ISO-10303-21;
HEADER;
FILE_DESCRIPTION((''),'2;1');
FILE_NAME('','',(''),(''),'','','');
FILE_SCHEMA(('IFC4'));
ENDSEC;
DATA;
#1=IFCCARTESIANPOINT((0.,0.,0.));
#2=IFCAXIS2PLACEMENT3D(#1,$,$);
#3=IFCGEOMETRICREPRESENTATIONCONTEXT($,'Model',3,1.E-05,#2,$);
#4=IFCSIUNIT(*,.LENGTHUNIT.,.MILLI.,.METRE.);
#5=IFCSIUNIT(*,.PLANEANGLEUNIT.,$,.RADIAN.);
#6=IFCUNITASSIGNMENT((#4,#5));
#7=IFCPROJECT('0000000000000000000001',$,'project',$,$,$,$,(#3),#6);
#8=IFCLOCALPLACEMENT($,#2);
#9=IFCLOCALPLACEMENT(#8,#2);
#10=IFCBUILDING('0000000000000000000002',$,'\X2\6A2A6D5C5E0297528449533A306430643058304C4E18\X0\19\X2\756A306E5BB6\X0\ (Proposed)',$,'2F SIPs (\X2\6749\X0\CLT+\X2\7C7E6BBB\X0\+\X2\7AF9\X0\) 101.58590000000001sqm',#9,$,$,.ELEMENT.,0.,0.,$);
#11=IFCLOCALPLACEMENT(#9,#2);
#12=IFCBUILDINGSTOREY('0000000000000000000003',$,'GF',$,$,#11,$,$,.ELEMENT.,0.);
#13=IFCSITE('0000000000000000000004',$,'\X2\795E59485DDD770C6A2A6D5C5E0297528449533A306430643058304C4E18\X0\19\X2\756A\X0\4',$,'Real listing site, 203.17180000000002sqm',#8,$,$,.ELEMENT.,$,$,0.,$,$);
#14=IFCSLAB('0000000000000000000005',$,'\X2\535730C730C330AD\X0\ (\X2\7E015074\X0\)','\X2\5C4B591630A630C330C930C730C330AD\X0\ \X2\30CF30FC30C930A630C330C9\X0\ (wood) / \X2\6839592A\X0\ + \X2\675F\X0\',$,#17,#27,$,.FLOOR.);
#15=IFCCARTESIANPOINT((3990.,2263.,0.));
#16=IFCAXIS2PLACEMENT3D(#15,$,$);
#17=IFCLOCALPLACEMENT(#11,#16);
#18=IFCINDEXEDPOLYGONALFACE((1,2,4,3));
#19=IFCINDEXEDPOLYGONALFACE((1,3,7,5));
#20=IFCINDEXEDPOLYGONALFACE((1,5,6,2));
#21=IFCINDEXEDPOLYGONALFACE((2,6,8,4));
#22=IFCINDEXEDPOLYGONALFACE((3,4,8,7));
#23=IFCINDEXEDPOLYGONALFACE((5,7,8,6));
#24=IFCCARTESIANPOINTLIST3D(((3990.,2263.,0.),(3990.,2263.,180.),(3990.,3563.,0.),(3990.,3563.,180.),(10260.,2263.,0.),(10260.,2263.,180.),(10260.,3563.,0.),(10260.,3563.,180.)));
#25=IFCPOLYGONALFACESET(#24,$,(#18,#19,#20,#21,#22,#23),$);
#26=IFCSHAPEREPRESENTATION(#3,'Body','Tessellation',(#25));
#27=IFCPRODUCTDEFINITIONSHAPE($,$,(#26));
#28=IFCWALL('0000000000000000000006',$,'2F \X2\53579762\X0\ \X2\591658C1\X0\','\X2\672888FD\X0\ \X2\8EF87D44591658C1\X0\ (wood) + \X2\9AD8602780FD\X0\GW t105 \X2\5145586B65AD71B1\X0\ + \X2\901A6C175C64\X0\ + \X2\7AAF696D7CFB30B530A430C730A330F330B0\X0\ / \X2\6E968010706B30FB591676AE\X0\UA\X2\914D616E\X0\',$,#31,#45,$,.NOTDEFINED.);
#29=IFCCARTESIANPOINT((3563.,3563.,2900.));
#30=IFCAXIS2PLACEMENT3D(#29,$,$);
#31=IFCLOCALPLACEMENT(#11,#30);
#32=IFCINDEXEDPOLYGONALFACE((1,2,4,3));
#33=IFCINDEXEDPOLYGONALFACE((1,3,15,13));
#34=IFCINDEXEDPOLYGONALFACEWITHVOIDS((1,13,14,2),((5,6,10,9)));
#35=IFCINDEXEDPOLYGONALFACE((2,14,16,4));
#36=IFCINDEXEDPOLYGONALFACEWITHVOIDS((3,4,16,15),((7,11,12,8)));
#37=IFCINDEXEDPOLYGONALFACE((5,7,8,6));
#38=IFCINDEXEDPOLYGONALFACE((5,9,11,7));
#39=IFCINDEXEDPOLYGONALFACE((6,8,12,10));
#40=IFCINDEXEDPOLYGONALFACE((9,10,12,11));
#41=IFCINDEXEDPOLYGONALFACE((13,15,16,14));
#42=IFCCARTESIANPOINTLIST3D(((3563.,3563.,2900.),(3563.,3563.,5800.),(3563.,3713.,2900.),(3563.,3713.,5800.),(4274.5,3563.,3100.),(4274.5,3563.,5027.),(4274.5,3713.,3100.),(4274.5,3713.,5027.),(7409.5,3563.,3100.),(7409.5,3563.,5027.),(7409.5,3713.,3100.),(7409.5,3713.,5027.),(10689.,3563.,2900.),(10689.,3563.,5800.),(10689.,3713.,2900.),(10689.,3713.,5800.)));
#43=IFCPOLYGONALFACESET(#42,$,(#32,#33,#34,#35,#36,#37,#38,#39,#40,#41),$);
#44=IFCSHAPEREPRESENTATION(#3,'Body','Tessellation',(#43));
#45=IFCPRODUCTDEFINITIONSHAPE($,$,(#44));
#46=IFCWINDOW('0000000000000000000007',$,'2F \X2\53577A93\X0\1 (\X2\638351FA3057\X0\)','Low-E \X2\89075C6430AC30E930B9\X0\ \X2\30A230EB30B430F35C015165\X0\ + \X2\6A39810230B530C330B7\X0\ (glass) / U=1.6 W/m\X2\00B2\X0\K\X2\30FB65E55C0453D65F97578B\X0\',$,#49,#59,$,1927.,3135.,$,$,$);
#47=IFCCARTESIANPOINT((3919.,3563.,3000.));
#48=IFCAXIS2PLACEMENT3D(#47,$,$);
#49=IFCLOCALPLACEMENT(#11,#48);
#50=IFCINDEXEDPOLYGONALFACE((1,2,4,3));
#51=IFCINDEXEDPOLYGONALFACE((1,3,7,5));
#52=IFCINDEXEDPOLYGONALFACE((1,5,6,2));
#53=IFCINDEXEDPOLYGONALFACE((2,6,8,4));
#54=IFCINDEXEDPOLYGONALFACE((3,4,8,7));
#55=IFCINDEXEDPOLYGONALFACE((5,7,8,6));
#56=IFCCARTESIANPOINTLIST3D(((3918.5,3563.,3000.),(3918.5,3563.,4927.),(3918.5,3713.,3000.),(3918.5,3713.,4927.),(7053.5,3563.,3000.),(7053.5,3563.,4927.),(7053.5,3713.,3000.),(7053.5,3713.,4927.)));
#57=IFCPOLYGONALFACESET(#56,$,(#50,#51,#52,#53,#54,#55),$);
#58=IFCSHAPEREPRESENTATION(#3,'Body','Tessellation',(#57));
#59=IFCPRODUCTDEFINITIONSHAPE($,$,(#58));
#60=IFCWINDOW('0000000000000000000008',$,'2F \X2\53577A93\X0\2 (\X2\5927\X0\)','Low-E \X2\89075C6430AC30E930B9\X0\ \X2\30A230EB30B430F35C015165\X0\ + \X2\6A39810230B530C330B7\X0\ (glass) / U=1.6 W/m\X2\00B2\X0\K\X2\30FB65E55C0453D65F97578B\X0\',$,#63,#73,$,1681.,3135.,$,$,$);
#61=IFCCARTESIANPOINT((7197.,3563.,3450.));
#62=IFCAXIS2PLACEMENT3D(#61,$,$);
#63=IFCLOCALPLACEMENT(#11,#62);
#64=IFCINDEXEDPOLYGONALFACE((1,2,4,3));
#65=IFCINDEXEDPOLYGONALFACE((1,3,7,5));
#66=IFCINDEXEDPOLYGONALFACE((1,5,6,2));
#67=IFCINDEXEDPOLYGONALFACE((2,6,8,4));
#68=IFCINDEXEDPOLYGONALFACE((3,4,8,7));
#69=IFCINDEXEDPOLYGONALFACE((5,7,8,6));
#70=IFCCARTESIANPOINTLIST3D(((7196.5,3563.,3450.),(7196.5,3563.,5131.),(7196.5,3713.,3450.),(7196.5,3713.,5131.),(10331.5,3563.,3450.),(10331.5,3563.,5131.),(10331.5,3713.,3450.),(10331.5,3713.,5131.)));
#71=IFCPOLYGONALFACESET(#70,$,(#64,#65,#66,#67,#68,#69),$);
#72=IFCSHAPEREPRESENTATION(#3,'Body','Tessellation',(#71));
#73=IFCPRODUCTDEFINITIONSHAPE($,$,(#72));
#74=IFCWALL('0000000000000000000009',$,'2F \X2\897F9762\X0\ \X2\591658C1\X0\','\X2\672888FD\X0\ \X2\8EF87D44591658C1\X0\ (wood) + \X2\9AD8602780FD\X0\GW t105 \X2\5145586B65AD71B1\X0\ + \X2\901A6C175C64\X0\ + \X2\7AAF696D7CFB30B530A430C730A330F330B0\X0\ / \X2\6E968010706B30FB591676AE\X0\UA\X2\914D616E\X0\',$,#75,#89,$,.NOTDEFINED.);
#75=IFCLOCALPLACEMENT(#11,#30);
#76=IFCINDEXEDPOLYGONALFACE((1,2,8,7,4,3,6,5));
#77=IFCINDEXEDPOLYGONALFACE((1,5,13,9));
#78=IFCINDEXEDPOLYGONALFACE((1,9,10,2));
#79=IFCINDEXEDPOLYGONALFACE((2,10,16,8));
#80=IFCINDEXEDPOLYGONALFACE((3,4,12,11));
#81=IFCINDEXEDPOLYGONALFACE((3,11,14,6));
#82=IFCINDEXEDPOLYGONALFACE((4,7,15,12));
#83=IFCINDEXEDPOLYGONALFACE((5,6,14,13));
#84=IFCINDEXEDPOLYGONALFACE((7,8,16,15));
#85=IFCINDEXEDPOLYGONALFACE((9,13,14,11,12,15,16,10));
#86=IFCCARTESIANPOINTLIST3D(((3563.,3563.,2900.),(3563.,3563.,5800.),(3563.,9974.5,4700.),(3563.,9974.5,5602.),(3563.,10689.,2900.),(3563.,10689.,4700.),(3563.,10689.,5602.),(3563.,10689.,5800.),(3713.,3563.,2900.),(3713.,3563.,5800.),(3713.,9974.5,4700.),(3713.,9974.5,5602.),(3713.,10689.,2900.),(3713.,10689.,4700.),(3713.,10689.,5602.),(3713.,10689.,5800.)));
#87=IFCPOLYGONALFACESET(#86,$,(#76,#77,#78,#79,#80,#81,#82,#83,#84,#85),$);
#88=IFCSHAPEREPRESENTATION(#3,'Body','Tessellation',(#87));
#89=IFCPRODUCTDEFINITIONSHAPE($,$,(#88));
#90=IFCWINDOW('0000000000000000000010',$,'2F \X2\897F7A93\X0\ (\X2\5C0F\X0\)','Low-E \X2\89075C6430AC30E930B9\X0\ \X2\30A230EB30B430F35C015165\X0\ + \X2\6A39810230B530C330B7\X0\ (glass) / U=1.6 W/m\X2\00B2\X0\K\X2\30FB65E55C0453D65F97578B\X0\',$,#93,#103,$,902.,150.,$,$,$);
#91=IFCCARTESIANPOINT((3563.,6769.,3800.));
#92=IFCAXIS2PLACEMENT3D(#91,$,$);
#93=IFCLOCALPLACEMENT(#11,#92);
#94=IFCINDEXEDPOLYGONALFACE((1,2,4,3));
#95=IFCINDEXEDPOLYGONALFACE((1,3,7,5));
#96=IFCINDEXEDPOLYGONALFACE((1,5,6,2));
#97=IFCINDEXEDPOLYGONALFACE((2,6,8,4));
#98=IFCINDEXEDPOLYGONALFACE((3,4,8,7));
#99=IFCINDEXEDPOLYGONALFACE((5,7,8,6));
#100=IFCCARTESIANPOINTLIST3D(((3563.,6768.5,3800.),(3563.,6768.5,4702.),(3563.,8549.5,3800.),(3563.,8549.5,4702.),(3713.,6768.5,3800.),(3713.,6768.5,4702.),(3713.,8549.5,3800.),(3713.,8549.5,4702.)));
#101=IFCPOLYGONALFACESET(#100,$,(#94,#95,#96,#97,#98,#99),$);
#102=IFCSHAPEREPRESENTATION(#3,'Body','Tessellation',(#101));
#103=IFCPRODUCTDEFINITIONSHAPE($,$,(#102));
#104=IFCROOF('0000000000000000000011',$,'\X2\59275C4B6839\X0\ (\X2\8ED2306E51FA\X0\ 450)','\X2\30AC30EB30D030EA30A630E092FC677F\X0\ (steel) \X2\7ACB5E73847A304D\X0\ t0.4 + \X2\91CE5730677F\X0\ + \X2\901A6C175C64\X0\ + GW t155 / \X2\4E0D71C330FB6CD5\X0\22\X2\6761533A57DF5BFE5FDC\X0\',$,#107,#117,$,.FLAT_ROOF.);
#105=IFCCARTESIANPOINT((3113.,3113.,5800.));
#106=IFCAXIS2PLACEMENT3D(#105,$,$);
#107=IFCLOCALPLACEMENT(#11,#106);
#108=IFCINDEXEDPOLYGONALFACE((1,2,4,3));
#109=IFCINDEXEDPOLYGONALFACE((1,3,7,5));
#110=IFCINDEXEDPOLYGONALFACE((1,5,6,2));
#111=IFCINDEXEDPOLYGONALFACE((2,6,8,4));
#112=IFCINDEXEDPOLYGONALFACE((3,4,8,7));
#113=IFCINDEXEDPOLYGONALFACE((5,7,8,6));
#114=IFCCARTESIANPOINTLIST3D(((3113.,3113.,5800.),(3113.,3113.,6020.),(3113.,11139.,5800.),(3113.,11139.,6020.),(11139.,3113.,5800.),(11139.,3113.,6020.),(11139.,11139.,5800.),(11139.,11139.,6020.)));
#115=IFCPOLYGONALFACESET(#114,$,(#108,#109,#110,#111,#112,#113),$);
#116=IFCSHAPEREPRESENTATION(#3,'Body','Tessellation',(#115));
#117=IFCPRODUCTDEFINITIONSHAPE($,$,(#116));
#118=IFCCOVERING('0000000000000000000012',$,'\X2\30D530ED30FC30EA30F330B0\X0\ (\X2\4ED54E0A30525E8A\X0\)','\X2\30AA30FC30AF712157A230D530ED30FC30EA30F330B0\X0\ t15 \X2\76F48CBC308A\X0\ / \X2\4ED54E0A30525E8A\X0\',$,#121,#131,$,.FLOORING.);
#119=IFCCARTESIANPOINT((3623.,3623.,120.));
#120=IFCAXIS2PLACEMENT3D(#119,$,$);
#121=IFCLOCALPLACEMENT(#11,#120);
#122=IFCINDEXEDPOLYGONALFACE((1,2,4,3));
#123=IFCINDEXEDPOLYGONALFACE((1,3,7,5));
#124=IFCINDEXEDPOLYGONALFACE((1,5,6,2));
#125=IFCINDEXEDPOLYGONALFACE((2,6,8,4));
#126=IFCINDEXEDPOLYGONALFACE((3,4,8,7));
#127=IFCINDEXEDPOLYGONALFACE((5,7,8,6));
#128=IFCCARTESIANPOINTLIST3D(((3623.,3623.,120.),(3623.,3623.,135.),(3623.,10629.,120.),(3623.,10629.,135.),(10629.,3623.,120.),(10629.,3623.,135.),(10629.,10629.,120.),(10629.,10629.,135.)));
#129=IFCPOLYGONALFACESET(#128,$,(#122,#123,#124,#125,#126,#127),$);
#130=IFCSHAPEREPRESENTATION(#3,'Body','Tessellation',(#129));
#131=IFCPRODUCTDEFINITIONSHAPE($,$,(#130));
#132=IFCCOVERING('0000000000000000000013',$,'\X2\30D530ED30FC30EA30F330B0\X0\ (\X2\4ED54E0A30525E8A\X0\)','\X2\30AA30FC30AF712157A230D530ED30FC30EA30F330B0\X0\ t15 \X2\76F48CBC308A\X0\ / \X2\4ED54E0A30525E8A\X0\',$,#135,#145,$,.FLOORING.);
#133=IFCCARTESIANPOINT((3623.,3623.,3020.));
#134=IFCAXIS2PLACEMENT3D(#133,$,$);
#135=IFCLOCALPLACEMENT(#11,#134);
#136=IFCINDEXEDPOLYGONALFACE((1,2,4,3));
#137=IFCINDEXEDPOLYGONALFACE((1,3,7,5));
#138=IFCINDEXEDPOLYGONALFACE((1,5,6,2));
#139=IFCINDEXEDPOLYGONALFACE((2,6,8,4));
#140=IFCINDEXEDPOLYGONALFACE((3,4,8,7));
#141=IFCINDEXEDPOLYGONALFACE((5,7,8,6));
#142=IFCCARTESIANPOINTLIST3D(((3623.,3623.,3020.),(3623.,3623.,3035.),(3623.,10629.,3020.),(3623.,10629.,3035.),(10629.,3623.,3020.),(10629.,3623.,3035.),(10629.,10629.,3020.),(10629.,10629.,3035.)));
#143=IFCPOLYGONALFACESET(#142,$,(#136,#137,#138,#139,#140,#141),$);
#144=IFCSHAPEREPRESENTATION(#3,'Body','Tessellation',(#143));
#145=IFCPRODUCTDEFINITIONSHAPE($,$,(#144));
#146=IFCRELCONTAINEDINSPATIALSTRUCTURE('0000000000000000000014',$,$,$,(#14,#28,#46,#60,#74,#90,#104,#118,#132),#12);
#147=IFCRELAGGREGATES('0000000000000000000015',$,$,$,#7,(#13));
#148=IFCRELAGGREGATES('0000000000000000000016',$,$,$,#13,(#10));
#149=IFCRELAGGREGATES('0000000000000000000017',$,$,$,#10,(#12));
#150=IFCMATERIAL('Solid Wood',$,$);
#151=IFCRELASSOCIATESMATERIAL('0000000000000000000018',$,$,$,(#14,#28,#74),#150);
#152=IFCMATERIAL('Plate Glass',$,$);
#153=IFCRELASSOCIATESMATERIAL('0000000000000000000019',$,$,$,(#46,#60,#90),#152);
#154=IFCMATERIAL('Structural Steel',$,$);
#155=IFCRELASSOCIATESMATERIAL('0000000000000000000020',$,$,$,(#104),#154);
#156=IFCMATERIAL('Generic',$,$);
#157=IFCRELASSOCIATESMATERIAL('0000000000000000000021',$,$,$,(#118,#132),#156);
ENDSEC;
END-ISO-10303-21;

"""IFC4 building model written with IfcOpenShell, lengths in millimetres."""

from ifc_helpers import new_model, si_unit, frame, frame_2d, origin, place, context, project, spatial, rectangle, extrude, material, element, fill, save


model = new_model("IFC4")

# Units and contexts
model_context = context("Model", 3, precision=1e-05, world=origin())
ifc_project = project(units=[si_unit("LENGTHUNIT", "METRE", prefix="MILLI"), si_unit("PLANEANGLEUNIT", "RADIAN")], contexts=[model_context])

# Site, building, storey
site_placement = place(None, origin())
site = spatial("IfcSite", under=ifc_project, at=site_placement, Name="神奈川県横浜市青葉区つつじが丘19番4", ObjectType="Real listing site, 203.17180000000002sqm", CompositionType="ELEMENT", RefElevation=0.0)
building_placement = place(site_placement, origin())
building = spatial("IfcBuilding", under=site, at=building_placement, Name="横浜市青葉区つつじが丘19番の家 (Proposed)", ObjectType="2F SIPs (杉CLT+籾殻+竹) 101.58590000000001sqm", CompositionType="ELEMENT", ElevationOfRefHeight=0.0, ElevationOfTerrain=0.0)
storey_placement = place(building_placement, origin())
storey = spatial("IfcBuildingStorey", under=building, at=storey_placement, Name="GF", CompositionType="ELEMENT", Elevation=0.0)

# Slab
ifc_material_1 = material(Name="Solid Wood")
slab_1_placement = place(storey_placement, frame((3990.0, 2263.0, 0.0)))
element("IfcSlab", 1, at=slab_1_placement, inside=storey, material=ifc_material_1, Name="南デッキ (縁側)", Description="屋外ウッドデッキ ハードウッド (wood) / 根太 + 束", PredefinedType="FLOOR", context=model_context, shape_type="SweptSolid", body=[
    extrude(rectangle(XDim=6270.0, YDim=1300.0, at=frame_2d((3135.0, 650.0))), frame((3990.0, 2263.0, 0.0)), (0.0, 0.0, 1.0), 180.0),
])

# Shared definitions
ifc_material_2 = material(Name="Plate Glass")

# Wall, openings, windows
wall_1_placement = place(storey_placement, frame((3563.0, 3563.0, 2900.0)))
wall_1 = element("IfcWall", 2, at=wall_1_placement, inside=storey, material=ifc_material_1, Name="2F 南面 外壁", Description="木製 軸組外壁 (wood) + 高性能GW t105 充填断熱 + 通気層 + 窯業系サイディング / 準耐火・外皮UA配慮", PredefinedType="NOTDEFINED", context=model_context, shape_type="SweptSolid", body=[
    extrude(rectangle(XDim=7126.0, YDim=150.0, at=frame_2d((3563.0, 75.0))), frame((3563.0, 3563.0, 2900.0)), (0.0, 0.0, 1.0), 2900.0),
])
opening_1_placement = place(storey_placement, frame((3919.0, 3563.0, 3000.0)))
opening_1 = element("IfcOpeningElement", 3, at=opening_1_placement, cuts=wall_1, PredefinedType="NOTDEFINED", context=model_context, shape_type="SweptSolid", body=[
    extrude(rectangle(XDim=3135.0, YDim=150.0, at=frame_2d((1567.0, 75.0))), frame((3919.0, 3563.0, 3000.0)), (0.0, 0.0, 1.0), 1927.0),
])
opening_2_placement = place(storey_placement, frame((7197.0, 3563.0, 3450.0)))
opening_2 = element("IfcOpeningElement", 4, at=opening_2_placement, cuts=wall_1, PredefinedType="NOTDEFINED", context=model_context, shape_type="SweptSolid", body=[
    extrude(rectangle(XDim=3135.0, YDim=150.0, at=frame_2d((1567.0, 75.0))), frame((7197.0, 3563.0, 3450.0)), (0.0, 0.0, 1.0), 1681.0),
])
window_1_placement = place(storey_placement, frame((3919.0, 3563.0, 3000.0)))
window_1 = element("IfcWindow", 5, at=window_1_placement, inside=storey, material=ifc_material_2, Name="2F 南窓1 (掃出し)", Description="Low-E 複層ガラス アルゴン封入 + 樹脂サッシ (glass) / U=1.6 W/m²K・日射取得型", OverallHeight=1927.0, OverallWidth=3135.0, context=model_context, shape_type="SweptSolid", body=[
    extrude(rectangle(XDim=3135.0, YDim=150.0, at=frame_2d((1567.0, 75.0))), frame((3919.0, 3563.0, 3000.0)), (0.0, 0.0, 1.0), 1927.0),
])
fill(opening_1, window_1)
window_2_placement = place(storey_placement, frame((7197.0, 3563.0, 3450.0)))
window_2 = element("IfcWindow", 6, at=window_2_placement, inside=storey, material=ifc_material_2, Name="2F 南窓2 (大)", Description="Low-E 複層ガラス アルゴン封入 + 樹脂サッシ (glass) / U=1.6 W/m²K・日射取得型", OverallHeight=1681.0, OverallWidth=3135.0, context=model_context, shape_type="SweptSolid", body=[
    extrude(rectangle(XDim=3135.0, YDim=150.0, at=frame_2d((1567.0, 75.0))), frame((7197.0, 3563.0, 3450.0)), (0.0, 0.0, 1.0), 1681.0),
])
fill(opening_2, window_2)

# Wall, opening, window
wall_2_placement = place(storey_placement, frame((3563.0, 3563.0, 2900.0)))
wall_2 = element("IfcWall", 7, at=wall_2_placement, inside=storey, material=ifc_material_1, Name="2F 西面 外壁", Description="木製 軸組外壁 (wood) + 高性能GW t105 充填断熱 + 通気層 + 窯業系サイディング / 準耐火・外皮UA配慮", PredefinedType="NOTDEFINED", context=model_context, shape_type="SweptSolid", body=[
    extrude(rectangle(XDim=150.0, YDim=7126.0, at=frame_2d((75.0, 3563.0))), frame((3563.0, 3563.0, 2900.0)), (0.0, 0.0, 1.0), 2900.0),
])
opening_3_placement = place(storey_placement, frame((3563.0, 6769.0, 3800.0)))
opening_3 = element("IfcOpeningElement", 8, at=opening_3_placement, cuts=wall_2, PredefinedType="NOTDEFINED", context=model_context, shape_type="SweptSolid", body=[
    extrude(rectangle(XDim=150.0, YDim=1781.0, at=frame_2d((75.0, 890.0))), frame((3563.0, 6769.0, 3800.0)), (0.0, 0.0, 1.0), 902.0),
])
window_3_placement = place(storey_placement, frame((3563.0, 6769.0, 3800.0)))
window_3 = element("IfcWindow", 9, at=window_3_placement, inside=storey, material=ifc_material_2, Name="2F 西窓 (小)", Description="Low-E 複層ガラス アルゴン封入 + 樹脂サッシ (glass) / U=1.6 W/m²K・日射取得型", OverallHeight=902.0, OverallWidth=150.0, context=model_context, shape_type="SweptSolid", body=[
    extrude(rectangle(XDim=150.0, YDim=1781.0, at=frame_2d((75.0, 890.0))), frame((3563.0, 6769.0, 3800.0)), (0.0, 0.0, 1.0), 902.0),
])
fill(opening_3, window_3)

# Roof
ifc_material_3 = material(Name="Structural Steel")
roof_placement = place(storey_placement, frame((3113.0, 3113.0, 5800.0)))
element("IfcRoof", 10, at=roof_placement, inside=storey, material=ifc_material_3, Name="大屋根 (軒の出 450)", Description="ガルバリウム鋼板 (steel) 立平葺き t0.4 + 野地板 + 通気層 + GW t155 / 不燃・法22条区域対応", PredefinedType="FLAT_ROOF", context=model_context, shape_type="SweptSolid", body=[
    extrude(rectangle(XDim=8026.0, YDim=8026.0, at=frame_2d((4013.0, 4013.0))), frame((3113.0, 3113.0, 5800.0)), (0.0, 0.0, 1.0), 220.0),
])

# Coverings
ifc_material_4 = material(Name="Generic")
covering_1_placement = place(storey_placement, frame((3623.0, 3623.0, 120.0)))
element("IfcCovering", 11, at=covering_1_placement, inside=storey, material=ifc_material_4, Name="フローリング (仕上げ床)", Description="オーク無垢フローリング t15 直貼り / 仕上げ床", PredefinedType="FLOORING", context=model_context, shape_type="SweptSolid", body=[
    extrude(rectangle(XDim=7006.0, YDim=7006.0, at=frame_2d((3503.0, 3503.0))), frame((3623.0, 3623.0, 120.0)), (0.0, 0.0, 1.0), 15.0),
])
covering_2_placement = place(storey_placement, frame((3623.0, 3623.0, 3020.0)))
element("IfcCovering", 12, at=covering_2_placement, inside=storey, material=ifc_material_4, Name="フローリング (仕上げ床)", Description="オーク無垢フローリング t15 直貼り / 仕上げ床", PredefinedType="FLOORING", context=model_context, shape_type="SweptSolid", body=[
    extrude(rectangle(XDim=7006.0, YDim=7006.0, at=frame_2d((3503.0, 3503.0))), frame((3623.0, 3623.0, 3020.0)), (0.0, 0.0, 1.0), 15.0),
])

save(model, "model.ifc")
